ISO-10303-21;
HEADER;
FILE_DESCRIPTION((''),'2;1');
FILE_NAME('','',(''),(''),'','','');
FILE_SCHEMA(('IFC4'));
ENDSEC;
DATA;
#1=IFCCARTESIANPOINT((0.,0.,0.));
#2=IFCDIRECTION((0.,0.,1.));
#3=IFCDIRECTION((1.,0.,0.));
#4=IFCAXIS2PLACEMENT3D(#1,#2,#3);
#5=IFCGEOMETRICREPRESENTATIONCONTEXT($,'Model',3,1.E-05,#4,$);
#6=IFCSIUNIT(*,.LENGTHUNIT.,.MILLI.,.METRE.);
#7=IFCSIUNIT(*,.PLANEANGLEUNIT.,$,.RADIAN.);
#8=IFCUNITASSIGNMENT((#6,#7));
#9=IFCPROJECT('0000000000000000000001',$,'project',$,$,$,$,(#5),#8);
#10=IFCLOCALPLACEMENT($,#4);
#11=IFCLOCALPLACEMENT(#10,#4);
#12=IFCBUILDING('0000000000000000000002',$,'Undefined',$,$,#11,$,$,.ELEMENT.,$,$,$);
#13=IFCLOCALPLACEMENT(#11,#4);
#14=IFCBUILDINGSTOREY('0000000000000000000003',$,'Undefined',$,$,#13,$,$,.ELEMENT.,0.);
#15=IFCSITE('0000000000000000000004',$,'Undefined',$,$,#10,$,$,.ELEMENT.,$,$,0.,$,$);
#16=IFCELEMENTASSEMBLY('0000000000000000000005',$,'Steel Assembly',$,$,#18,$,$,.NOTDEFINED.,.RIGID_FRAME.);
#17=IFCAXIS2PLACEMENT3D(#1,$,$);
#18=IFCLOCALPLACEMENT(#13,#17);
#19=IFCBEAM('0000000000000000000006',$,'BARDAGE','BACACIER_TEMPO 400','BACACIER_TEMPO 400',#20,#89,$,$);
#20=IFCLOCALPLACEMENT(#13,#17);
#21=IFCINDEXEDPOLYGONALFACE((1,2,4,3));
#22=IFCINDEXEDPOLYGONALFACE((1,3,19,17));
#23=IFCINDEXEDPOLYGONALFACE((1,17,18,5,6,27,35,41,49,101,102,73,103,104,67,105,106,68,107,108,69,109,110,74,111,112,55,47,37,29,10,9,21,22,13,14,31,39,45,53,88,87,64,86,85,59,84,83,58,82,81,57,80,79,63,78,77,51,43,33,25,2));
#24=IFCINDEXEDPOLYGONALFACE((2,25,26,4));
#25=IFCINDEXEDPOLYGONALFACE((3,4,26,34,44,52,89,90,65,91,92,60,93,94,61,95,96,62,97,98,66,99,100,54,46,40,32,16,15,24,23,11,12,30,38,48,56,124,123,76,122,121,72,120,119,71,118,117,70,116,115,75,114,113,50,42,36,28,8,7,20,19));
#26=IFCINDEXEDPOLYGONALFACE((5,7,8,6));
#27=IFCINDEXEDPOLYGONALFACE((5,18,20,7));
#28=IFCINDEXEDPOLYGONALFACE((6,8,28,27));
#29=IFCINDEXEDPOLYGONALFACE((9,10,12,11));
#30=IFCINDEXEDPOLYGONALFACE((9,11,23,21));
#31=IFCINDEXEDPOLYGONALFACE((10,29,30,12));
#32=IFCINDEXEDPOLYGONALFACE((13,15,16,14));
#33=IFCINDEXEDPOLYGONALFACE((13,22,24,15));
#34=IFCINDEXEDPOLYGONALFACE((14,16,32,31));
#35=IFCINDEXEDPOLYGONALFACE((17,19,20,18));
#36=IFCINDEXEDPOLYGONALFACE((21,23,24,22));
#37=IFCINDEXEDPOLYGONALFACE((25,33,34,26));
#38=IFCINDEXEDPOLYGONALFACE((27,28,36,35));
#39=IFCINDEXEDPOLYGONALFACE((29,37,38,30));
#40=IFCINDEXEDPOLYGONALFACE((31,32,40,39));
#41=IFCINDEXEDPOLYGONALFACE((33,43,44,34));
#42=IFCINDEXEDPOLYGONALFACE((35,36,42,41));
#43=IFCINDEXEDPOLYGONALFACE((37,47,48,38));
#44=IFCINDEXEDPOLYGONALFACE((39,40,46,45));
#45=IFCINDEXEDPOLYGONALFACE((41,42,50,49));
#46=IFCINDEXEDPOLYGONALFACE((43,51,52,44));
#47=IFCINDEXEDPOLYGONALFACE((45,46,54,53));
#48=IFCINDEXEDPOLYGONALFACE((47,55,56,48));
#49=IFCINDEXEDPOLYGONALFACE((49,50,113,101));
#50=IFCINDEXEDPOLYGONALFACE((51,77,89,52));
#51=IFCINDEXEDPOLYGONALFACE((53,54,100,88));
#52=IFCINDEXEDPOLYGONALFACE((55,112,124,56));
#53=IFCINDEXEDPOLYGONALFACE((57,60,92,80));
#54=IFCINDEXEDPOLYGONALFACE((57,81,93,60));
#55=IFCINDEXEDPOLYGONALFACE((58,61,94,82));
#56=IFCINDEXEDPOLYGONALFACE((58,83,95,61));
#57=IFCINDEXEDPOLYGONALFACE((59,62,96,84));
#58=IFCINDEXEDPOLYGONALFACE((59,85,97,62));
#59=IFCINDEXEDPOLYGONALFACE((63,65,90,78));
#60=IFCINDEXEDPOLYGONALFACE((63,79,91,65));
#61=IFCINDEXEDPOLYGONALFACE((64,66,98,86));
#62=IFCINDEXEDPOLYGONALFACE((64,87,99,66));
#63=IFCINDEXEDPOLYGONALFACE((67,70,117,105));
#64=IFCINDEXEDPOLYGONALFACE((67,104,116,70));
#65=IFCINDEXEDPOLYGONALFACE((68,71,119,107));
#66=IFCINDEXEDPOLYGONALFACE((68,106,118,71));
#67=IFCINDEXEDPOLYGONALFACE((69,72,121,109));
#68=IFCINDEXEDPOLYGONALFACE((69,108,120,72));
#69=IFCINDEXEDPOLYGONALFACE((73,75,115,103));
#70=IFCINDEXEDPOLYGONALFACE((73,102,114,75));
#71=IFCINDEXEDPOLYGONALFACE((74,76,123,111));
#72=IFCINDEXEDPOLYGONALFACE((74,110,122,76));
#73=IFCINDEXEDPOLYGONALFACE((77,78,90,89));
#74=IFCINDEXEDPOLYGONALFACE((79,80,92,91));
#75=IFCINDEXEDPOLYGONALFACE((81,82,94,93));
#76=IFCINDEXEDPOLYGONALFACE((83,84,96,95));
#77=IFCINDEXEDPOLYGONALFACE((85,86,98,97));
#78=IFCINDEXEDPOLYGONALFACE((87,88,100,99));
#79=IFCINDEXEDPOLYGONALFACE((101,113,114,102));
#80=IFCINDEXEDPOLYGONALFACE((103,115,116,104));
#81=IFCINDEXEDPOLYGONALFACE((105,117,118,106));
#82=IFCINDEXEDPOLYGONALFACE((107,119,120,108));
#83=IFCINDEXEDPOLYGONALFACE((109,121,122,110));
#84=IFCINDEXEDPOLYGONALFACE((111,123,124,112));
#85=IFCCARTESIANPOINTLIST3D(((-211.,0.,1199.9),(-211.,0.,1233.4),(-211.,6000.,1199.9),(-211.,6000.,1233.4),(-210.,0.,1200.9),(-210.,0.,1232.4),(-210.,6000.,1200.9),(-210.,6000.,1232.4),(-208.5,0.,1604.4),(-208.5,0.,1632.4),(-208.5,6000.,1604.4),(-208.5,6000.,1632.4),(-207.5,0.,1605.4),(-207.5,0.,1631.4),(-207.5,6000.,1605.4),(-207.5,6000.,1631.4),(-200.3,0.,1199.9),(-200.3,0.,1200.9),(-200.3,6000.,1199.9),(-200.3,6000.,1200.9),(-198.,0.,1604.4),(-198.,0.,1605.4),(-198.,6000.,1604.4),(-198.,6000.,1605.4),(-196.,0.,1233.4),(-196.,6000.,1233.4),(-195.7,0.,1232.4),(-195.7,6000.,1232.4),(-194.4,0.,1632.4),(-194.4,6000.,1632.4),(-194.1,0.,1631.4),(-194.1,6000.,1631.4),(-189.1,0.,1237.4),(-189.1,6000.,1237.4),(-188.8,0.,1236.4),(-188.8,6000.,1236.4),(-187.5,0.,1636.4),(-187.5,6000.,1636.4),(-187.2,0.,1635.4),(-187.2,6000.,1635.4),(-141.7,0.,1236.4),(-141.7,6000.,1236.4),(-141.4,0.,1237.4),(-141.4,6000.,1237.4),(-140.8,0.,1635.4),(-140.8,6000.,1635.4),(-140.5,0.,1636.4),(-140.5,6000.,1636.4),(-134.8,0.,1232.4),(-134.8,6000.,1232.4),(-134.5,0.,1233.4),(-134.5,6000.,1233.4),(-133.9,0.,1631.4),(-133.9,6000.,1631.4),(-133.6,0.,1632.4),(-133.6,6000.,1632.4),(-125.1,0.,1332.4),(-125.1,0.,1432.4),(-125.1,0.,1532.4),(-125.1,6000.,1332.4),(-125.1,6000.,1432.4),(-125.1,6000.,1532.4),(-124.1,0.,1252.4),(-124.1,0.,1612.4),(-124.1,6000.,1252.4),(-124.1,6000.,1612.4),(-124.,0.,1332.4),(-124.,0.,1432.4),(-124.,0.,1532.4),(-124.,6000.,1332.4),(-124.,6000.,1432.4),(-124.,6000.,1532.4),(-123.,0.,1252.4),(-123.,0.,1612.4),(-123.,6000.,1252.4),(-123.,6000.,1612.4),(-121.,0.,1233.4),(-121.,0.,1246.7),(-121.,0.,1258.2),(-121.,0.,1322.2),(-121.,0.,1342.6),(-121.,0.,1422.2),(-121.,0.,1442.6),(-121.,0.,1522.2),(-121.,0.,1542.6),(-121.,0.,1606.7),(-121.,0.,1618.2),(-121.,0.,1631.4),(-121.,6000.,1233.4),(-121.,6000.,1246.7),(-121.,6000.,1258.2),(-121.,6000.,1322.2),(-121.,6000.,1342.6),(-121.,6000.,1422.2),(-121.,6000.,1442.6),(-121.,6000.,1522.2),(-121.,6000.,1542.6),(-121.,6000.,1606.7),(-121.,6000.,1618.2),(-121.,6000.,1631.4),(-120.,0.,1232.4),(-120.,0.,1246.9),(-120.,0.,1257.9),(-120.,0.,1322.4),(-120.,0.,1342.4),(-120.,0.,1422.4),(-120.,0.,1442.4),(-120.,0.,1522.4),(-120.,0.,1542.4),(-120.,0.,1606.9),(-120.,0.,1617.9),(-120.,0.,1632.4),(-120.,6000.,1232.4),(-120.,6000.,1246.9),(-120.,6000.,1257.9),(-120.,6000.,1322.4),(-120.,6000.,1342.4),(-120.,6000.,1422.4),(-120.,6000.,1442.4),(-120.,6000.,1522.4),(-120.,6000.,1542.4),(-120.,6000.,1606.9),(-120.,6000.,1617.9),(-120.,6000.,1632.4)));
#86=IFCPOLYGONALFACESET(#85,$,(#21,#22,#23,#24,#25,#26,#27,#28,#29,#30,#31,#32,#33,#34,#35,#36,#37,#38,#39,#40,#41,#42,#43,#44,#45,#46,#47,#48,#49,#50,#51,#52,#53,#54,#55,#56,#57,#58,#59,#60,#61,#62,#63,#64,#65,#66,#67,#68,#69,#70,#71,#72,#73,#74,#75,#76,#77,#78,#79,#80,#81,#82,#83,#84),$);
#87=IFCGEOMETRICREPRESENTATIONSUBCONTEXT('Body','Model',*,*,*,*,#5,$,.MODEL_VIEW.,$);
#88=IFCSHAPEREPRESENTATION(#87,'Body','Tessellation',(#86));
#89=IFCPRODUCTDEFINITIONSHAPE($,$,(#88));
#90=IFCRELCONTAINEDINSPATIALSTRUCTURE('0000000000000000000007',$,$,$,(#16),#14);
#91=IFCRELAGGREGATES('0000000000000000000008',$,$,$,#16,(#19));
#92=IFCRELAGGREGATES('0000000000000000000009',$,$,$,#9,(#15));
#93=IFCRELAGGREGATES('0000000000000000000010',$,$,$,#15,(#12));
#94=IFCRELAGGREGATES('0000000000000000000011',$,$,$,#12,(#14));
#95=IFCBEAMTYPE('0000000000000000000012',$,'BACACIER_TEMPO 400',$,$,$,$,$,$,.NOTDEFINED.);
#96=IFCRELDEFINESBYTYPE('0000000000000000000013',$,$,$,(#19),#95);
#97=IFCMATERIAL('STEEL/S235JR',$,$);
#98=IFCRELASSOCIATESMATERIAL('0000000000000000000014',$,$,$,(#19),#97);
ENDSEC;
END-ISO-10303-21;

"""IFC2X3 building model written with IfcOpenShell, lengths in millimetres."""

from ifc_helpers import new_model, si_unit, frame, origin_with_axes, place, context, subcontext, project, spatial, polyline, outline, extrude, material, type_object, element, aggregate, save


model = new_model("IFC2X3")

# Units and contexts
model_context = context("Model", 3, precision=1e-05, world=origin_with_axes())
body_context = subcontext(model_context, "Body", "Model", "MODEL_VIEW")
ifc_project = project(units=[si_unit("LENGTHUNIT", "METRE", prefix="MILLI"), si_unit("PLANEANGLEUNIT", "RADIAN")], contexts=[model_context])

# Site, building, storey
site_placement = place(None, origin_with_axes())
site = spatial("IfcSite", under=ifc_project, at=site_placement, Name="Undefined", CompositionType="ELEMENT", RefElevation=0.0)
building_placement = place(site_placement, origin_with_axes())
building = spatial("IfcBuilding", under=site, at=building_placement, Name="Undefined", CompositionType="ELEMENT")
storey_placement = place(building_placement, origin_with_axes())
storey = spatial("IfcBuildingStorey", under=building, at=storey_placement, Name="Undefined", CompositionType="ELEMENT", Elevation=0.0)

# Element assembly, beam
ifc_material_1 = material(Name="STEEL/S235JR")
beam_type_1 = type_object("IfcBeamType", Name="BACACIER_TEMPO 400", PredefinedType="NOTDEFINED")
assembly_1_placement = place(storey_placement, origin_with_axes())
assembly_1 = element("IfcElementAssembly", 1, at=assembly_1_placement, inside=storey, Name="Steel Assembly", AssemblyPlace="NOTDEFINED", PredefinedType="RIGID_FRAME")
beam_1_placement = place(assembly_1_placement, frame((-165.5, 0.0, 1418.2), z_axis=(-1.0, 0.0, 0.0), x_axis=(0.0, 1.0, 0.0)))
beam_1 = element("IfcBeam", 2, at=beam_1_placement, type_object=beam_type_1, material=ifc_material_1, Name="BARDAGE", Description="BACACIER_TEMPO 400", ObjectType="BACACIER_TEMPO 400", context=body_context, shape_type="SweptSolid", body=[
    extrude(outline(polyline([(218.2, -25.0), (214.2, -31.9), (214.2, -45.5), (199.8, -45.5), (194.2, -42.5), (188.8, -45.5), (124.2, -45.5), (114.2, -41.5), (104.2, -45.5), (24.2, -45.5), (14.2, -41.5), (4.2, -45.5), (-75.8, -45.5), (-85.8, -41.5), (-95.8, -45.5), (-160.2, -45.5), (-165.8, -42.5), (-171.2, -45.5), (-185.8, -45.5), (-185.8, -30.7), (-181.8, -23.8), (-181.8, 23.3), (-185.8, 30.2), (-185.8, 44.5), (-217.2, 44.5), (-217.2, 34.8), (-218.2, 34.8), (-218.2, 45.5), (-184.8, 45.5), (-184.8, 30.5), (-180.8, 23.6), (-180.8, -24.1), (-184.8, -31.0), (-184.8, -44.5), (-171.5, -44.5), (-165.8, -41.4), (-160.0, -44.5), (-95.9, -44.5), (-85.8, -40.4), (-75.6, -44.5), (4.1, -44.5), (14.2, -40.4), (24.4, -44.5), (104.1, -44.5), (114.2, -40.4), (124.4, -44.5), (188.5, -44.5), (194.2, -41.4), (200.0, -44.5), (213.2, -44.5), (213.2, -31.6), (217.2, -24.7), (217.2, 21.7), (213.2, 28.6), (213.2, 42.0), (187.2, 42.0), (187.2, 32.5), (186.2, 32.5), (186.2, 43.0), (214.2, 43.0), (214.2, 28.9), (218.2, 22.0), (218.2, -25.0)])), frame((6000.0, 0.0, 0.0), z_axis=(-1.0, 0.0, 0.0), x_axis=(0.0, -1.0, 0.0)), (0.0, 0.0, 1.0), 6000.0),
])
aggregate(assembly_1, [beam_1])

save(model, "model.ifc")
